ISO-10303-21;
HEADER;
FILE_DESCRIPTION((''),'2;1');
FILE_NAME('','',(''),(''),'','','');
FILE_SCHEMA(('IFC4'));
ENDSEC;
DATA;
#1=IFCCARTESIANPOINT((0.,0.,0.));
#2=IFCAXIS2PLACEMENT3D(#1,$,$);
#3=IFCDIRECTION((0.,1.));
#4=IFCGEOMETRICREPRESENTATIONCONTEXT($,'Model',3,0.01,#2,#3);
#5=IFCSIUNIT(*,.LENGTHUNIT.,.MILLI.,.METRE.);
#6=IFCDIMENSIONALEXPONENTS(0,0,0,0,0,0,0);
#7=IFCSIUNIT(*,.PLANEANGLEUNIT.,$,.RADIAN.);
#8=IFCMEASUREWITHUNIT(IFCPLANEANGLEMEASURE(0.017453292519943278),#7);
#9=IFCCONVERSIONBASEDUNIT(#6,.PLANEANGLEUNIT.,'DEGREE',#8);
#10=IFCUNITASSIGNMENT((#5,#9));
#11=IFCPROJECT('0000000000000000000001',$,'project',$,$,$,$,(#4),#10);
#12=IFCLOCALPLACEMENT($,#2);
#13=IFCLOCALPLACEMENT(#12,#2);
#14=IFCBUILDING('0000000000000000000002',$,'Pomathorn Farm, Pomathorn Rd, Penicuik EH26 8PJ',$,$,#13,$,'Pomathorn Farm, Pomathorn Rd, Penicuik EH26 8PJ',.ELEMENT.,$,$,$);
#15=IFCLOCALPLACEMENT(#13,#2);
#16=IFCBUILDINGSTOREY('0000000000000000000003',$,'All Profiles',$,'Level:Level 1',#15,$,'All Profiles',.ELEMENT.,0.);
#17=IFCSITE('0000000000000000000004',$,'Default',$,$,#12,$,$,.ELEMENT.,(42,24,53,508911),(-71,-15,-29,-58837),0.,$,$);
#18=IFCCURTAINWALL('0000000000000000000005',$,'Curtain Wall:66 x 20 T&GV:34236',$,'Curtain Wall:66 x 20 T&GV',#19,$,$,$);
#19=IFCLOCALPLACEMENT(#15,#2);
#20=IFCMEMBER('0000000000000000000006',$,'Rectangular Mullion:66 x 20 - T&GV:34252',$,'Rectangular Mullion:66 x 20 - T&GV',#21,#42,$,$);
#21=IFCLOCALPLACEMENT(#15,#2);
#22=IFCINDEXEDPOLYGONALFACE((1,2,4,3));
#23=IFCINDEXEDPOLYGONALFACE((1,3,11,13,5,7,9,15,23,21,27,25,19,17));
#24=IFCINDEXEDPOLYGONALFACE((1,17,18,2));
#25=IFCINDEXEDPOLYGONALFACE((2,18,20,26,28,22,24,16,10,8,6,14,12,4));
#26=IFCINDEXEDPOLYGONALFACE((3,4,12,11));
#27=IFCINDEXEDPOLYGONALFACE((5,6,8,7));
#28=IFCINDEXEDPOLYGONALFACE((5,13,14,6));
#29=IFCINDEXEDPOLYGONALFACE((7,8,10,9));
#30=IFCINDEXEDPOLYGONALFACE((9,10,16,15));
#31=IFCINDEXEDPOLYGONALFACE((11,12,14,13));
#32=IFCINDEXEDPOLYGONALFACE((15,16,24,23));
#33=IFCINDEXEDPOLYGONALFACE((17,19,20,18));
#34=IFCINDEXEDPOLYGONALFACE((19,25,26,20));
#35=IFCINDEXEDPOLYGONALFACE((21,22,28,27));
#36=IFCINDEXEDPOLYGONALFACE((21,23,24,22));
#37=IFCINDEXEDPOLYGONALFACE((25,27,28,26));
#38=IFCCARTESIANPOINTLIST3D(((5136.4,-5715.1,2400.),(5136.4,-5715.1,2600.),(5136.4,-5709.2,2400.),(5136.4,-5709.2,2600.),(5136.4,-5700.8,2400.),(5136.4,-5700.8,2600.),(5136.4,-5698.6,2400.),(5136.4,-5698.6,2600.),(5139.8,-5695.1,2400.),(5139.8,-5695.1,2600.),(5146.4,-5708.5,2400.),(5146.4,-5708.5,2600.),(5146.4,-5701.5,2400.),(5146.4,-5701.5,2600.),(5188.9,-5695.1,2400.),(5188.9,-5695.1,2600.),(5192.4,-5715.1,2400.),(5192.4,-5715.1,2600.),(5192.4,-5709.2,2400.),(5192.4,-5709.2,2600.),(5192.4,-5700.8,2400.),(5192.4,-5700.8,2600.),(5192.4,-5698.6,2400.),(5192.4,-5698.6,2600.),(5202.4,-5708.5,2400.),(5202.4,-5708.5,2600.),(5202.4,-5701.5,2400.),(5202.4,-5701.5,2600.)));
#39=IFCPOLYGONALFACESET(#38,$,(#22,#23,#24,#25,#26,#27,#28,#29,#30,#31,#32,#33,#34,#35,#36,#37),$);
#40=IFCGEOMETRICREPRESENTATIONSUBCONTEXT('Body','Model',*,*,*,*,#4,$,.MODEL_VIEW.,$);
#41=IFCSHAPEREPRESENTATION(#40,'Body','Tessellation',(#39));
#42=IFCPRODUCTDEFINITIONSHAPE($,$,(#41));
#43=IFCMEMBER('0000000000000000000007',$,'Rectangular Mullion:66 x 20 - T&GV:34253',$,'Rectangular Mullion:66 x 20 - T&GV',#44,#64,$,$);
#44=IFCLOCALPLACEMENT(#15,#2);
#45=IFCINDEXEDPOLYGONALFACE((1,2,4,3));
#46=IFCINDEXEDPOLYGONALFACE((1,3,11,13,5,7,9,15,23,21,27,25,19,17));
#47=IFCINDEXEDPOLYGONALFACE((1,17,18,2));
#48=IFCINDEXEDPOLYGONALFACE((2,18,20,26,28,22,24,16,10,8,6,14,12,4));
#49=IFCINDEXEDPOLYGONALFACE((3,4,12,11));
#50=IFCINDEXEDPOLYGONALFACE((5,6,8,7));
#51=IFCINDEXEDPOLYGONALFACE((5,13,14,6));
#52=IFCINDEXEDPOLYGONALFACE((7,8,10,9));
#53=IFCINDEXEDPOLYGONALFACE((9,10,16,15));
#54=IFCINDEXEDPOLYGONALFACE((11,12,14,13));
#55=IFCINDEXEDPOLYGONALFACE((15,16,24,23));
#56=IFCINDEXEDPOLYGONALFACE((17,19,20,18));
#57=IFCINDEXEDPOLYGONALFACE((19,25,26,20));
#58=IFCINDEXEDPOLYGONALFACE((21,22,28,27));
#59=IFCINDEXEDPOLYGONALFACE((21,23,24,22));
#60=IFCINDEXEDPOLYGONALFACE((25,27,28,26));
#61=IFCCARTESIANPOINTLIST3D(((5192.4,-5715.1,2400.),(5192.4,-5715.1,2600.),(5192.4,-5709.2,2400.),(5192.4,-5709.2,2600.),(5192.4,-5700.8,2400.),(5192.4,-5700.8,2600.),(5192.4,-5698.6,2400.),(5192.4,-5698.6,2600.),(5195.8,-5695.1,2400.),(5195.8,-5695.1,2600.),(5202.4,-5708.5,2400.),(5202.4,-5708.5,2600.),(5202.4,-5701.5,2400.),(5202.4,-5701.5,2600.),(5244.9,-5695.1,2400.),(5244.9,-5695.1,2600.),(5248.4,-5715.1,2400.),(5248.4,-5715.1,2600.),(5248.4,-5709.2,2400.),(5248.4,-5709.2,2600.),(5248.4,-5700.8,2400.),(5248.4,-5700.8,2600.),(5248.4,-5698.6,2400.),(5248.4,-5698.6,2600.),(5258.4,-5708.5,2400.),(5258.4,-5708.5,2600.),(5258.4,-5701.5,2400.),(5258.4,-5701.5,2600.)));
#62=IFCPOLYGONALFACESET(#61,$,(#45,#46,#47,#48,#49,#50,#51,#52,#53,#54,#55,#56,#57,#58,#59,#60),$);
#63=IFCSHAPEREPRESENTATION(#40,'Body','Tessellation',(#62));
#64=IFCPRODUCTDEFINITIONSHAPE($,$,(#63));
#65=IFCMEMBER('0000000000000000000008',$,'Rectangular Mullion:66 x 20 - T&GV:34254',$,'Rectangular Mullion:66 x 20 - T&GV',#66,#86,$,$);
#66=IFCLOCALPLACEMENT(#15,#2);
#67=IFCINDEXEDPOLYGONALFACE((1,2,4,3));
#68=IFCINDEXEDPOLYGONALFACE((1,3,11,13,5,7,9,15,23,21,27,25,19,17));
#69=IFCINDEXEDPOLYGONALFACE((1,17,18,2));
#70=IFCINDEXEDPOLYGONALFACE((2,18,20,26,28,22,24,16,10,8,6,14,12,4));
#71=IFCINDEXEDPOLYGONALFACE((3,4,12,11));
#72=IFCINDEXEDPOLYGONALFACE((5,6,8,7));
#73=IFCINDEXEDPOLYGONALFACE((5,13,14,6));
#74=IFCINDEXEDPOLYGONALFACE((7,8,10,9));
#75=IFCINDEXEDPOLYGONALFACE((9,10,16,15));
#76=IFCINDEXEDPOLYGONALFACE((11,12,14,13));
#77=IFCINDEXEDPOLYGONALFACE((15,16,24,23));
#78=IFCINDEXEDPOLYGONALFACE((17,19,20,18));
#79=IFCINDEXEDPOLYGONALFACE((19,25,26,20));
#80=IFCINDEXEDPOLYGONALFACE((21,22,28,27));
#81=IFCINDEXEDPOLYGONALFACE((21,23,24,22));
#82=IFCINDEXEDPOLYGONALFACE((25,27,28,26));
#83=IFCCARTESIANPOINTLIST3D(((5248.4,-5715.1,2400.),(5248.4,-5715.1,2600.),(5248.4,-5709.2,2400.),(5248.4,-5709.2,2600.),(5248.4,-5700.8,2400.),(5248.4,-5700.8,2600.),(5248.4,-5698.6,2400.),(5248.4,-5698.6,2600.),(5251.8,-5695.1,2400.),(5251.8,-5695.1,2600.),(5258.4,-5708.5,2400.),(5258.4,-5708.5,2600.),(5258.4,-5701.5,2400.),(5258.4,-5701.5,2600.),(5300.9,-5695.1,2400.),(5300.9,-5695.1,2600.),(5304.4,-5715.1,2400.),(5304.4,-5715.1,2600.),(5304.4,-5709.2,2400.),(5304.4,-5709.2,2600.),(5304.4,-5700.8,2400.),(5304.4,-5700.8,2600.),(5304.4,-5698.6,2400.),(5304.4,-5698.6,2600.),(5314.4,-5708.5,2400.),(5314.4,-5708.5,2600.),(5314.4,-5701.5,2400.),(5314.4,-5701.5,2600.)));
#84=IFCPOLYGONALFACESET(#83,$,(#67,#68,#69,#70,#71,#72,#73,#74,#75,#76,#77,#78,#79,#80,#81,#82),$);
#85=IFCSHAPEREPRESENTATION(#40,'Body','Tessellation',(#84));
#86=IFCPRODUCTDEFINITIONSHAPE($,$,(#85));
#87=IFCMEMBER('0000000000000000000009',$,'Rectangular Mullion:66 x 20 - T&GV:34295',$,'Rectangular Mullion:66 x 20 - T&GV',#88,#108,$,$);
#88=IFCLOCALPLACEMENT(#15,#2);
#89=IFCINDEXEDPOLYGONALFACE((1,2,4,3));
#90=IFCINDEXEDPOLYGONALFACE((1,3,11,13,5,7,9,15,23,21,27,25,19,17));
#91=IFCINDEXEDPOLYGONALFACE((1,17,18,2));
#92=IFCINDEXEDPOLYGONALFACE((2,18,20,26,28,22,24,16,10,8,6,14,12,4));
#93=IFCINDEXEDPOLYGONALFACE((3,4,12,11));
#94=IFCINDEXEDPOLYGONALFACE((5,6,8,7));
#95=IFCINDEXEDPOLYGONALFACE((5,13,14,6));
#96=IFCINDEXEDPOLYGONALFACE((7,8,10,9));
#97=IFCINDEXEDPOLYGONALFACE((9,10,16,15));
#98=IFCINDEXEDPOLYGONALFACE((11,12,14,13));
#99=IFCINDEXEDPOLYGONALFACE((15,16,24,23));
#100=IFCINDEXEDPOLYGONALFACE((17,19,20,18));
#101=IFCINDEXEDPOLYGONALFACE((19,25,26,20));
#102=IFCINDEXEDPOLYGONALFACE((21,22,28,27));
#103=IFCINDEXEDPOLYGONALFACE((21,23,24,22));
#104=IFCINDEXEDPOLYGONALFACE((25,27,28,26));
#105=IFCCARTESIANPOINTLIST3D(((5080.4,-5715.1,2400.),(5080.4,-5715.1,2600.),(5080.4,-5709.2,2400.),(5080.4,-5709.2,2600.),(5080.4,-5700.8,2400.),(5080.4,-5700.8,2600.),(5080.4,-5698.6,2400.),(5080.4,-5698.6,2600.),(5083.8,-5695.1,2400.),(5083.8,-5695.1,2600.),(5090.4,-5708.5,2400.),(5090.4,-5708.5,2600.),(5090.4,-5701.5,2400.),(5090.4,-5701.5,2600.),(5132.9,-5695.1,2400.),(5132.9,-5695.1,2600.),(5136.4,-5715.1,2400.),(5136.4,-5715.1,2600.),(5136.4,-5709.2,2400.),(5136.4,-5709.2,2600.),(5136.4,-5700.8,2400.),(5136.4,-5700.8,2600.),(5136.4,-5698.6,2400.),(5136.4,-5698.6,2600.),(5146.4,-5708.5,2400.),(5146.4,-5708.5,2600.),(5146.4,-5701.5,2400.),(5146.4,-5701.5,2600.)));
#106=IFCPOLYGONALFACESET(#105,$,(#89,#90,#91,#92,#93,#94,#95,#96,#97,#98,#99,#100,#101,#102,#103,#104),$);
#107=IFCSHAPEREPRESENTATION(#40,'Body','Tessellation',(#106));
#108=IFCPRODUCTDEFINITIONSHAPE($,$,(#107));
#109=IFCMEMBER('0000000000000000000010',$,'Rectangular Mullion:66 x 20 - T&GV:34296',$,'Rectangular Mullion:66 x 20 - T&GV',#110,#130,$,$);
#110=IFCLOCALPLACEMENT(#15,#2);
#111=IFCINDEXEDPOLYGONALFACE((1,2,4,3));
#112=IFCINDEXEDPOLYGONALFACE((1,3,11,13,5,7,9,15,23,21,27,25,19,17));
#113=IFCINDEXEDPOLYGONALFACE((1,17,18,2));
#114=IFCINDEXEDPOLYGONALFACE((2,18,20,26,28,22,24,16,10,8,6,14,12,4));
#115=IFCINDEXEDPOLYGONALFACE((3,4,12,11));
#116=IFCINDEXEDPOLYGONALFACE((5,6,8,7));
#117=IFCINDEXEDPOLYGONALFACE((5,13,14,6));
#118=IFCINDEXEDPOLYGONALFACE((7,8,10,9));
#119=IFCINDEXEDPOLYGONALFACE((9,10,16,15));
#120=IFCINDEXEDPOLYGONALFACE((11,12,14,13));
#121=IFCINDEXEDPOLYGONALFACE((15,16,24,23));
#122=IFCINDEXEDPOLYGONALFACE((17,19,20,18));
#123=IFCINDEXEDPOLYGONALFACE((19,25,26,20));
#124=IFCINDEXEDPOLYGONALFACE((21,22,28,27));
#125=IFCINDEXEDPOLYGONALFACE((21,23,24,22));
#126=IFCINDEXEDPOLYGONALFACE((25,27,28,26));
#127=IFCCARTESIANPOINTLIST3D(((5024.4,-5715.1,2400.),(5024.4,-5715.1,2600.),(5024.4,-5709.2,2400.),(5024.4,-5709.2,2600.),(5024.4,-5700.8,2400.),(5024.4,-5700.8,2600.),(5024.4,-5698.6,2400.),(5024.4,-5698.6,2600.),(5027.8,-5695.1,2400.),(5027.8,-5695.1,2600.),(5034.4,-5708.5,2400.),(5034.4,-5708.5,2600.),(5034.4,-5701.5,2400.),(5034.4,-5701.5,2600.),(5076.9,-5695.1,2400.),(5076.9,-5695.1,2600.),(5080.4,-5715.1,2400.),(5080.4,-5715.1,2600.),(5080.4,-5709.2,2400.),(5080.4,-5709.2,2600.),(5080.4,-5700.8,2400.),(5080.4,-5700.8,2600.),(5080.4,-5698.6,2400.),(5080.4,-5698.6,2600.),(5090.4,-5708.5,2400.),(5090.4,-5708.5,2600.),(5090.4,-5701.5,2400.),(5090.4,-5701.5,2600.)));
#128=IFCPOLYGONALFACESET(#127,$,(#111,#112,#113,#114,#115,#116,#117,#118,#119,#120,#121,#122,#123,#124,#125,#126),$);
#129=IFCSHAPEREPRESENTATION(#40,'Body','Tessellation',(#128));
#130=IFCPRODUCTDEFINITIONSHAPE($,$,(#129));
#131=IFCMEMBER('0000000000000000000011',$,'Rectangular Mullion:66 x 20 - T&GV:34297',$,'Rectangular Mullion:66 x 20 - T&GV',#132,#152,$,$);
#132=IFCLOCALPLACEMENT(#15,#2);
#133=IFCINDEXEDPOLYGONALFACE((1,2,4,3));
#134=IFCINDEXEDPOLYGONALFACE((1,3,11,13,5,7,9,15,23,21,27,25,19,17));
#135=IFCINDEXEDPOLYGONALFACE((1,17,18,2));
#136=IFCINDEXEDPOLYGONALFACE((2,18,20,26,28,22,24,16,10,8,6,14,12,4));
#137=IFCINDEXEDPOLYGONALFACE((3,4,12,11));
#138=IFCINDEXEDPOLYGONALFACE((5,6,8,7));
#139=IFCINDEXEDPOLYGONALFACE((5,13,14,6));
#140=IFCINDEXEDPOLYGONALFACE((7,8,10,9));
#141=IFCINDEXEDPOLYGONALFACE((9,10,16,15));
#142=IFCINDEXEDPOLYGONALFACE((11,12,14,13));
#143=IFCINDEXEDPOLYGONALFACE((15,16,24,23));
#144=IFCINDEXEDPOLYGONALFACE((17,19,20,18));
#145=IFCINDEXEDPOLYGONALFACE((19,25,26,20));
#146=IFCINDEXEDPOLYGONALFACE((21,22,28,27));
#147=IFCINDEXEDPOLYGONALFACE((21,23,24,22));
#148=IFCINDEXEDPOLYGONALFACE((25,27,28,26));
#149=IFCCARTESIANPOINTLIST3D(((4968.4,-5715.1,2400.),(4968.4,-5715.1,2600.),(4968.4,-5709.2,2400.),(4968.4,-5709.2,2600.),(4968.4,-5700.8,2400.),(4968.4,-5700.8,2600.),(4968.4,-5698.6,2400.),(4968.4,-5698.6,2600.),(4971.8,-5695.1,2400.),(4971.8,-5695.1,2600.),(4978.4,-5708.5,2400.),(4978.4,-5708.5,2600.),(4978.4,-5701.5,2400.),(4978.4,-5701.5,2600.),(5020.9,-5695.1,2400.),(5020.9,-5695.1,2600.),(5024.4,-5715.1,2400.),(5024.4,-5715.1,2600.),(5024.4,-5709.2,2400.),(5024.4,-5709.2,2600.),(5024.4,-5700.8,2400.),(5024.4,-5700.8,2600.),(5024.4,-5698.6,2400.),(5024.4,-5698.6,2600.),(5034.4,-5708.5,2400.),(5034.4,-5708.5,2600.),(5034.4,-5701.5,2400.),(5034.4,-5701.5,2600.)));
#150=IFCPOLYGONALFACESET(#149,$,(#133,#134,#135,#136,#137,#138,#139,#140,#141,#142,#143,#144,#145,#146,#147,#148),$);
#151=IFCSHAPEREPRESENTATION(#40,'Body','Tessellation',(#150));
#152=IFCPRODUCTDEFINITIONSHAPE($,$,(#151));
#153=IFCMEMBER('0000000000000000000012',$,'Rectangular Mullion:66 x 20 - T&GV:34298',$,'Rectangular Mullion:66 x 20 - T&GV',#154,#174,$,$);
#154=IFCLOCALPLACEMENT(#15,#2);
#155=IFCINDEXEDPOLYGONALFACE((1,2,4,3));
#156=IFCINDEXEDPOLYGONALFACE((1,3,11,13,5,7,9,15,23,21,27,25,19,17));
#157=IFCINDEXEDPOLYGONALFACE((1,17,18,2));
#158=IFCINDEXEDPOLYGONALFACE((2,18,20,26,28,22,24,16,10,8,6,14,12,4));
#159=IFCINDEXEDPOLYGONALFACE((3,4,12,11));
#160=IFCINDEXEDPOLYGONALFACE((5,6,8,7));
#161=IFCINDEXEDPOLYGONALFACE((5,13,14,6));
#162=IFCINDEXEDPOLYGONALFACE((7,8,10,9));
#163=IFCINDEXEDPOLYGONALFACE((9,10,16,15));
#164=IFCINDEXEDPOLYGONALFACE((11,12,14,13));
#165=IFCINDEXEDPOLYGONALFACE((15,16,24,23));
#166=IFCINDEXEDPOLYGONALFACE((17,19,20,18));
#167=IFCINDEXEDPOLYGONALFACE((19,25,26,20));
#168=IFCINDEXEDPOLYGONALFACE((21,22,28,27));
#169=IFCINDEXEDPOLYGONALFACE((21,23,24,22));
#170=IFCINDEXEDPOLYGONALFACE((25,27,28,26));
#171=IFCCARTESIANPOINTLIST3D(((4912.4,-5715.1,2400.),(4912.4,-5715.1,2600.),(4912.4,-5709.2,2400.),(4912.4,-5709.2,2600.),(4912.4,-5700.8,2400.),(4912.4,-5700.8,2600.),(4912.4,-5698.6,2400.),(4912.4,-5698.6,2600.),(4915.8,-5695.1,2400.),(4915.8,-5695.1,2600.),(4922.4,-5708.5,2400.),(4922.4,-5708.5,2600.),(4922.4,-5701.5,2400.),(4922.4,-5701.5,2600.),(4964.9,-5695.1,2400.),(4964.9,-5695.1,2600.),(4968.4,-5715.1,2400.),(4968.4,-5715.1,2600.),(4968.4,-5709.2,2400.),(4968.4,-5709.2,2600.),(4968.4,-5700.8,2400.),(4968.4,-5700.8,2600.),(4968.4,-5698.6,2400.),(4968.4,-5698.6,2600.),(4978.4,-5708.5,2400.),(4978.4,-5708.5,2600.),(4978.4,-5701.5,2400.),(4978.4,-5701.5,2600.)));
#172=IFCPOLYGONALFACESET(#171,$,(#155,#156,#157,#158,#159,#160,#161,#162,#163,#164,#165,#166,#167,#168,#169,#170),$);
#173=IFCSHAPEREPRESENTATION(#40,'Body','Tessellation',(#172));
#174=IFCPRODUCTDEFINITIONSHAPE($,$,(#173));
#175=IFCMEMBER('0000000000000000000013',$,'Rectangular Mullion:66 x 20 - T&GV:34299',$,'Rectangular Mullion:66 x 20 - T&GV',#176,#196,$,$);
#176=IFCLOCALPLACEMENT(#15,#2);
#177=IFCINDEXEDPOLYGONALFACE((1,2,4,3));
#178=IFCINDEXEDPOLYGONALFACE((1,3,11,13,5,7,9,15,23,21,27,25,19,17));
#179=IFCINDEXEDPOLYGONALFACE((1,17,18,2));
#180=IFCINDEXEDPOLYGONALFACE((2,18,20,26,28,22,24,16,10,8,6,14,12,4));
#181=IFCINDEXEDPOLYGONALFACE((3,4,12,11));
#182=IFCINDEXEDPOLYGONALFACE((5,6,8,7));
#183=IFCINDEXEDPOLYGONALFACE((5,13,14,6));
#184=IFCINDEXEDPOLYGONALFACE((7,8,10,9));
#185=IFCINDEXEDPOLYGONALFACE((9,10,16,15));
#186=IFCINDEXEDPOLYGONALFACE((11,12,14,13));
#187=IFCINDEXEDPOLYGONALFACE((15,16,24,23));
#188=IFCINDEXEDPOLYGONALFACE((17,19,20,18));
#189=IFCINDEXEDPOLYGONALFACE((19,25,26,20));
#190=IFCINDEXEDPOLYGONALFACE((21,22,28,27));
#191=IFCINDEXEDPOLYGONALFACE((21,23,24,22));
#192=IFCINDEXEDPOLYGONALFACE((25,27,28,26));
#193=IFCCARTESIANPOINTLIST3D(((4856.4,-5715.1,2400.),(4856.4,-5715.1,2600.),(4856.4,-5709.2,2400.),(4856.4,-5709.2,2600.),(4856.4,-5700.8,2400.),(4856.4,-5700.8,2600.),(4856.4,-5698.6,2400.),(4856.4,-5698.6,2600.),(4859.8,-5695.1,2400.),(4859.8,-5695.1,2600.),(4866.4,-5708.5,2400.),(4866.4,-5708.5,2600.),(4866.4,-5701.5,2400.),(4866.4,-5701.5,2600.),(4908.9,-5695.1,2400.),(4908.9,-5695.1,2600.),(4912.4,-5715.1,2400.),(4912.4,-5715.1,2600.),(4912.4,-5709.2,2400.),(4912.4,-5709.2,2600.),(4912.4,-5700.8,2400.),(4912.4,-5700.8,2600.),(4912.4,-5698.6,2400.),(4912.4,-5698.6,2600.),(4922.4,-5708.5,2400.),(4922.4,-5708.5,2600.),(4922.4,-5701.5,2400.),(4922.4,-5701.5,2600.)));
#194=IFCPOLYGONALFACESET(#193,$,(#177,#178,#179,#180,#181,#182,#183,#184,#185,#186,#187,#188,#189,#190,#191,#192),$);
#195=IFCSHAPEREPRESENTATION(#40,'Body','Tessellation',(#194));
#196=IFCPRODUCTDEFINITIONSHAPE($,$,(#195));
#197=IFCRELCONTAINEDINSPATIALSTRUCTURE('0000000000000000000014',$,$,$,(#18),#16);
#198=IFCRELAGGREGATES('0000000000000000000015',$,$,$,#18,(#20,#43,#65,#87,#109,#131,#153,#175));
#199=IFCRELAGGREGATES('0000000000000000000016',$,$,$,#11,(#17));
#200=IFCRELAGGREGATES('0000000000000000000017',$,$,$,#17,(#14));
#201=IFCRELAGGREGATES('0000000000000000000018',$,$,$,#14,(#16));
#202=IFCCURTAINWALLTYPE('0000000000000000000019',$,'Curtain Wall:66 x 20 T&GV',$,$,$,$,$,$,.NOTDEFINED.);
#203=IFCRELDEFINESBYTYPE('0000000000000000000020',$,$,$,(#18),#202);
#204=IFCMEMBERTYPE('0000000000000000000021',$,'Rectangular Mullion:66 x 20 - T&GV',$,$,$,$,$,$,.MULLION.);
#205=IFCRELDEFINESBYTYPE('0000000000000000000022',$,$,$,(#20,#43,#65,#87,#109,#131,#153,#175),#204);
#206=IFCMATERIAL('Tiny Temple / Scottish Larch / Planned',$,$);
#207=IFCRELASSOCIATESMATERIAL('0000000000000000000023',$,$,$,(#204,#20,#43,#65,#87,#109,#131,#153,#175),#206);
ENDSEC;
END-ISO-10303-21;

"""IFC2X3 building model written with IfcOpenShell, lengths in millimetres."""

from ifc_helpers import new_model, entity, si_unit, converted_unit, direction, frame, origin, place, context, subcontext, project, spatial, polyline, outline, extrude, source, transform, mapped, material, type_object, type_shapes, element, aggregate, save


model = new_model("IFC2X3")

# Units and contexts
model_context = context("Model", 3, precision=0.01, world=origin(), true_north=direction((0.0, 1.0)))
body_context = subcontext(model_context, "Body", "Model", "MODEL_VIEW")
ifc_project = project(units=[si_unit("LENGTHUNIT", "METRE", prefix="MILLI"), converted_unit("PLANEANGLEUNIT", "DEGREE", entity("IfcPlaneAngleMeasure", 0.017453292519943278), si_unit("PLANEANGLEUNIT", "RADIAN"), dimensions=[0, 0, 0, 0, 0, 0, 0])], contexts=[model_context])

# Site, building, storey
site_placement = place(None, origin())
site = spatial("IfcSite", under=ifc_project, at=site_placement, Name="Default", CompositionType="ELEMENT", RefLatitude=(42, 24, 53, 508911), RefLongitude=(-71, -15, -29, -58837), RefElevation=0.0)
building_placement = place(site_placement, origin())
building = spatial("IfcBuilding", under=site, at=building_placement, Name="Pomathorn Farm, Pomathorn Rd, Penicuik EH26 8PJ", LongName="Pomathorn Farm, Pomathorn Rd, Penicuik EH26 8PJ", CompositionType="ELEMENT")
storey_placement = place(building_placement, origin())
storey = spatial("IfcBuildingStorey", under=building, at=storey_placement, Name="All Profiles", ObjectType="Level:Level 1", LongName="All Profiles", CompositionType="ELEMENT", Elevation=0.0)

# Curtain wall, members
curtain_wall_type = type_object("IfcCurtainWallType", Name="Curtain Wall:66 x 20 T&GV", PredefinedType="NOTDEFINED")
curtain_wall_placement = place(storey_placement, origin())
curtain_wall = element("IfcCurtainWall", 1, at=curtain_wall_placement, inside=storey, type_object=curtain_wall_type, Name="Curtain Wall:66 x 20 T&GV:34236", ObjectType="Curtain Wall:66 x 20 T&GV")
ifc_material = material(Name="Tiny Temple / Scottish Larch / Planned")
member_type = type_object("IfcMemberType", Name="Rectangular Mullion:66 x 20 - T&GV", PredefinedType="MULLION", material=ifc_material)
shared_shape = source(origin(), body_context, "Body", "SweptSolid", [
    extrude(outline(polyline([(-25.1, -11.0), (30.9, -11.0), (30.9, -5.1), (20.9, -4.4), (20.9, 2.6), (30.9, 3.3), (30.9, 5.5), (27.4, 9.0), (-21.7, 9.0), (-25.1, 5.5), (-25.1, 3.3), (-35.1, 2.6), (-35.1, -4.4), (-25.1, -5.1), (-25.1, -11.0)])), frame((-35.1, -11.0, -200.0), z_axis=(0.0, 0.0, 1.0), x_axis=(-1.0, 0.0, 0.0)), (0.0, 0.0, 1.0), 200.0),
])
type_shapes(member_type, [shared_shape])
member_1_placement = place(curtain_wall_placement, frame((5202.4, -5715.1, 2400.0), z_axis=(0.0, 0.0, -1.0), x_axis=(1.0, 0.0, 0.0)))
member_1 = element("IfcMember", 2, at=member_1_placement, type_object=member_type, material=ifc_material, Name="Rectangular Mullion:66 x 20 - T&GV:34252", ObjectType="Rectangular Mullion:66 x 20 - T&GV", context=body_context, shape_type="MappedRepresentation", body=[
    mapped(shared_shape, transform((0.0, 0.0, 0.0), scale=1.0)),
])
member_2_placement = place(curtain_wall_placement, frame((5258.4, -5715.1, 2400.0), z_axis=(0.0, 0.0, -1.0), x_axis=(1.0, 0.0, 0.0)))
member_2 = element("IfcMember", 3, at=member_2_placement, type_object=member_type, material=ifc_material, Name="Rectangular Mullion:66 x 20 - T&GV:34253", ObjectType="Rectangular Mullion:66 x 20 - T&GV", context=body_context, shape_type="MappedRepresentation", body=[
    mapped(shared_shape, transform((0.0, 0.0, 0.0), scale=1.0)),
])
member_3_placement = place(curtain_wall_placement, frame((5314.4, -5715.1, 2400.0), z_axis=(0.0, 0.0, -1.0), x_axis=(1.0, 0.0, 0.0)))
member_3 = element("IfcMember", 4, at=member_3_placement, type_object=member_type, material=ifc_material, Name="Rectangular Mullion:66 x 20 - T&GV:34254", ObjectType="Rectangular Mullion:66 x 20 - T&GV", context=body_context, shape_type="MappedRepresentation", body=[
    mapped(shared_shape, transform((0.0, 0.0, 0.0), scale=1.0)),
])
member_4_placement = place(curtain_wall_placement, frame((5146.4, -5715.1, 2400.0), z_axis=(0.0, 0.0, -1.0), x_axis=(1.0, 0.0, 0.0)))
member_4 = element("IfcMember", 5, at=member_4_placement, type_object=member_type, material=ifc_material, Name="Rectangular Mullion:66 x 20 - T&GV:34295", ObjectType="Rectangular Mullion:66 x 20 - T&GV", context=body_context, shape_type="MappedRepresentation", body=[
    mapped(shared_shape, transform((0.0, 0.0, 0.0), scale=1.0)),
])
member_5_placement = place(curtain_wall_placement, frame((5090.4, -5715.1, 2400.0), z_axis=(0.0, 0.0, -1.0), x_axis=(1.0, 0.0, 0.0)))
member_5 = element("IfcMember", 6, at=member_5_placement, type_object=member_type, material=ifc_material, Name="Rectangular Mullion:66 x 20 - T&GV:34296", ObjectType="Rectangular Mullion:66 x 20 - T&GV", context=body_context, shape_type="MappedRepresentation", body=[
    mapped(shared_shape, transform((0.0, 0.0, 0.0), scale=1.0)),
])
member_6_placement = place(curtain_wall_placement, frame((5034.4, -5715.1, 2400.0), z_axis=(0.0, 0.0, -1.0), x_axis=(1.0, 0.0, 0.0)))
member_6 = element("IfcMember", 7, at=member_6_placement, type_object=member_type, material=ifc_material, Name="Rectangular Mullion:66 x 20 - T&GV:34297", ObjectType="Rectangular Mullion:66 x 20 - T&GV", context=body_context, shape_type="MappedRepresentation", body=[
    mapped(shared_shape, transform((0.0, 0.0, 0.0), scale=1.0)),
])
member_7_placement = place(curtain_wall_placement, frame((4978.4, -5715.1, 2400.0), z_axis=(0.0, 0.0, -1.0), x_axis=(1.0, 0.0, 0.0)))
member_7 = element("IfcMember", 8, at=member_7_placement, type_object=member_type, material=ifc_material, Name="Rectangular Mullion:66 x 20 - T&GV:34298", ObjectType="Rectangular Mullion:66 x 20 - T&GV", context=body_context, shape_type="MappedRepresentation", body=[
    mapped(shared_shape, transform((0.0, 0.0, 0.0), scale=1.0)),
])
member_8_placement = place(curtain_wall_placement, frame((4922.4, -5715.1, 2400.0), z_axis=(0.0, 0.0, -1.0), x_axis=(1.0, 0.0, 0.0)))
member_8 = element("IfcMember", 9, at=member_8_placement, type_object=member_type, material=ifc_material, Name="Rectangular Mullion:66 x 20 - T&GV:34299", ObjectType="Rectangular Mullion:66 x 20 - T&GV", context=body_context, shape_type="MappedRepresentation", body=[
    mapped(shared_shape, transform((0.0, 0.0, 0.0), scale=1.0)),
])
aggregate(curtain_wall, [member_1, member_2, member_3, member_4, member_5, member_6, member_7, member_8])

save(model, "model.ifc")
